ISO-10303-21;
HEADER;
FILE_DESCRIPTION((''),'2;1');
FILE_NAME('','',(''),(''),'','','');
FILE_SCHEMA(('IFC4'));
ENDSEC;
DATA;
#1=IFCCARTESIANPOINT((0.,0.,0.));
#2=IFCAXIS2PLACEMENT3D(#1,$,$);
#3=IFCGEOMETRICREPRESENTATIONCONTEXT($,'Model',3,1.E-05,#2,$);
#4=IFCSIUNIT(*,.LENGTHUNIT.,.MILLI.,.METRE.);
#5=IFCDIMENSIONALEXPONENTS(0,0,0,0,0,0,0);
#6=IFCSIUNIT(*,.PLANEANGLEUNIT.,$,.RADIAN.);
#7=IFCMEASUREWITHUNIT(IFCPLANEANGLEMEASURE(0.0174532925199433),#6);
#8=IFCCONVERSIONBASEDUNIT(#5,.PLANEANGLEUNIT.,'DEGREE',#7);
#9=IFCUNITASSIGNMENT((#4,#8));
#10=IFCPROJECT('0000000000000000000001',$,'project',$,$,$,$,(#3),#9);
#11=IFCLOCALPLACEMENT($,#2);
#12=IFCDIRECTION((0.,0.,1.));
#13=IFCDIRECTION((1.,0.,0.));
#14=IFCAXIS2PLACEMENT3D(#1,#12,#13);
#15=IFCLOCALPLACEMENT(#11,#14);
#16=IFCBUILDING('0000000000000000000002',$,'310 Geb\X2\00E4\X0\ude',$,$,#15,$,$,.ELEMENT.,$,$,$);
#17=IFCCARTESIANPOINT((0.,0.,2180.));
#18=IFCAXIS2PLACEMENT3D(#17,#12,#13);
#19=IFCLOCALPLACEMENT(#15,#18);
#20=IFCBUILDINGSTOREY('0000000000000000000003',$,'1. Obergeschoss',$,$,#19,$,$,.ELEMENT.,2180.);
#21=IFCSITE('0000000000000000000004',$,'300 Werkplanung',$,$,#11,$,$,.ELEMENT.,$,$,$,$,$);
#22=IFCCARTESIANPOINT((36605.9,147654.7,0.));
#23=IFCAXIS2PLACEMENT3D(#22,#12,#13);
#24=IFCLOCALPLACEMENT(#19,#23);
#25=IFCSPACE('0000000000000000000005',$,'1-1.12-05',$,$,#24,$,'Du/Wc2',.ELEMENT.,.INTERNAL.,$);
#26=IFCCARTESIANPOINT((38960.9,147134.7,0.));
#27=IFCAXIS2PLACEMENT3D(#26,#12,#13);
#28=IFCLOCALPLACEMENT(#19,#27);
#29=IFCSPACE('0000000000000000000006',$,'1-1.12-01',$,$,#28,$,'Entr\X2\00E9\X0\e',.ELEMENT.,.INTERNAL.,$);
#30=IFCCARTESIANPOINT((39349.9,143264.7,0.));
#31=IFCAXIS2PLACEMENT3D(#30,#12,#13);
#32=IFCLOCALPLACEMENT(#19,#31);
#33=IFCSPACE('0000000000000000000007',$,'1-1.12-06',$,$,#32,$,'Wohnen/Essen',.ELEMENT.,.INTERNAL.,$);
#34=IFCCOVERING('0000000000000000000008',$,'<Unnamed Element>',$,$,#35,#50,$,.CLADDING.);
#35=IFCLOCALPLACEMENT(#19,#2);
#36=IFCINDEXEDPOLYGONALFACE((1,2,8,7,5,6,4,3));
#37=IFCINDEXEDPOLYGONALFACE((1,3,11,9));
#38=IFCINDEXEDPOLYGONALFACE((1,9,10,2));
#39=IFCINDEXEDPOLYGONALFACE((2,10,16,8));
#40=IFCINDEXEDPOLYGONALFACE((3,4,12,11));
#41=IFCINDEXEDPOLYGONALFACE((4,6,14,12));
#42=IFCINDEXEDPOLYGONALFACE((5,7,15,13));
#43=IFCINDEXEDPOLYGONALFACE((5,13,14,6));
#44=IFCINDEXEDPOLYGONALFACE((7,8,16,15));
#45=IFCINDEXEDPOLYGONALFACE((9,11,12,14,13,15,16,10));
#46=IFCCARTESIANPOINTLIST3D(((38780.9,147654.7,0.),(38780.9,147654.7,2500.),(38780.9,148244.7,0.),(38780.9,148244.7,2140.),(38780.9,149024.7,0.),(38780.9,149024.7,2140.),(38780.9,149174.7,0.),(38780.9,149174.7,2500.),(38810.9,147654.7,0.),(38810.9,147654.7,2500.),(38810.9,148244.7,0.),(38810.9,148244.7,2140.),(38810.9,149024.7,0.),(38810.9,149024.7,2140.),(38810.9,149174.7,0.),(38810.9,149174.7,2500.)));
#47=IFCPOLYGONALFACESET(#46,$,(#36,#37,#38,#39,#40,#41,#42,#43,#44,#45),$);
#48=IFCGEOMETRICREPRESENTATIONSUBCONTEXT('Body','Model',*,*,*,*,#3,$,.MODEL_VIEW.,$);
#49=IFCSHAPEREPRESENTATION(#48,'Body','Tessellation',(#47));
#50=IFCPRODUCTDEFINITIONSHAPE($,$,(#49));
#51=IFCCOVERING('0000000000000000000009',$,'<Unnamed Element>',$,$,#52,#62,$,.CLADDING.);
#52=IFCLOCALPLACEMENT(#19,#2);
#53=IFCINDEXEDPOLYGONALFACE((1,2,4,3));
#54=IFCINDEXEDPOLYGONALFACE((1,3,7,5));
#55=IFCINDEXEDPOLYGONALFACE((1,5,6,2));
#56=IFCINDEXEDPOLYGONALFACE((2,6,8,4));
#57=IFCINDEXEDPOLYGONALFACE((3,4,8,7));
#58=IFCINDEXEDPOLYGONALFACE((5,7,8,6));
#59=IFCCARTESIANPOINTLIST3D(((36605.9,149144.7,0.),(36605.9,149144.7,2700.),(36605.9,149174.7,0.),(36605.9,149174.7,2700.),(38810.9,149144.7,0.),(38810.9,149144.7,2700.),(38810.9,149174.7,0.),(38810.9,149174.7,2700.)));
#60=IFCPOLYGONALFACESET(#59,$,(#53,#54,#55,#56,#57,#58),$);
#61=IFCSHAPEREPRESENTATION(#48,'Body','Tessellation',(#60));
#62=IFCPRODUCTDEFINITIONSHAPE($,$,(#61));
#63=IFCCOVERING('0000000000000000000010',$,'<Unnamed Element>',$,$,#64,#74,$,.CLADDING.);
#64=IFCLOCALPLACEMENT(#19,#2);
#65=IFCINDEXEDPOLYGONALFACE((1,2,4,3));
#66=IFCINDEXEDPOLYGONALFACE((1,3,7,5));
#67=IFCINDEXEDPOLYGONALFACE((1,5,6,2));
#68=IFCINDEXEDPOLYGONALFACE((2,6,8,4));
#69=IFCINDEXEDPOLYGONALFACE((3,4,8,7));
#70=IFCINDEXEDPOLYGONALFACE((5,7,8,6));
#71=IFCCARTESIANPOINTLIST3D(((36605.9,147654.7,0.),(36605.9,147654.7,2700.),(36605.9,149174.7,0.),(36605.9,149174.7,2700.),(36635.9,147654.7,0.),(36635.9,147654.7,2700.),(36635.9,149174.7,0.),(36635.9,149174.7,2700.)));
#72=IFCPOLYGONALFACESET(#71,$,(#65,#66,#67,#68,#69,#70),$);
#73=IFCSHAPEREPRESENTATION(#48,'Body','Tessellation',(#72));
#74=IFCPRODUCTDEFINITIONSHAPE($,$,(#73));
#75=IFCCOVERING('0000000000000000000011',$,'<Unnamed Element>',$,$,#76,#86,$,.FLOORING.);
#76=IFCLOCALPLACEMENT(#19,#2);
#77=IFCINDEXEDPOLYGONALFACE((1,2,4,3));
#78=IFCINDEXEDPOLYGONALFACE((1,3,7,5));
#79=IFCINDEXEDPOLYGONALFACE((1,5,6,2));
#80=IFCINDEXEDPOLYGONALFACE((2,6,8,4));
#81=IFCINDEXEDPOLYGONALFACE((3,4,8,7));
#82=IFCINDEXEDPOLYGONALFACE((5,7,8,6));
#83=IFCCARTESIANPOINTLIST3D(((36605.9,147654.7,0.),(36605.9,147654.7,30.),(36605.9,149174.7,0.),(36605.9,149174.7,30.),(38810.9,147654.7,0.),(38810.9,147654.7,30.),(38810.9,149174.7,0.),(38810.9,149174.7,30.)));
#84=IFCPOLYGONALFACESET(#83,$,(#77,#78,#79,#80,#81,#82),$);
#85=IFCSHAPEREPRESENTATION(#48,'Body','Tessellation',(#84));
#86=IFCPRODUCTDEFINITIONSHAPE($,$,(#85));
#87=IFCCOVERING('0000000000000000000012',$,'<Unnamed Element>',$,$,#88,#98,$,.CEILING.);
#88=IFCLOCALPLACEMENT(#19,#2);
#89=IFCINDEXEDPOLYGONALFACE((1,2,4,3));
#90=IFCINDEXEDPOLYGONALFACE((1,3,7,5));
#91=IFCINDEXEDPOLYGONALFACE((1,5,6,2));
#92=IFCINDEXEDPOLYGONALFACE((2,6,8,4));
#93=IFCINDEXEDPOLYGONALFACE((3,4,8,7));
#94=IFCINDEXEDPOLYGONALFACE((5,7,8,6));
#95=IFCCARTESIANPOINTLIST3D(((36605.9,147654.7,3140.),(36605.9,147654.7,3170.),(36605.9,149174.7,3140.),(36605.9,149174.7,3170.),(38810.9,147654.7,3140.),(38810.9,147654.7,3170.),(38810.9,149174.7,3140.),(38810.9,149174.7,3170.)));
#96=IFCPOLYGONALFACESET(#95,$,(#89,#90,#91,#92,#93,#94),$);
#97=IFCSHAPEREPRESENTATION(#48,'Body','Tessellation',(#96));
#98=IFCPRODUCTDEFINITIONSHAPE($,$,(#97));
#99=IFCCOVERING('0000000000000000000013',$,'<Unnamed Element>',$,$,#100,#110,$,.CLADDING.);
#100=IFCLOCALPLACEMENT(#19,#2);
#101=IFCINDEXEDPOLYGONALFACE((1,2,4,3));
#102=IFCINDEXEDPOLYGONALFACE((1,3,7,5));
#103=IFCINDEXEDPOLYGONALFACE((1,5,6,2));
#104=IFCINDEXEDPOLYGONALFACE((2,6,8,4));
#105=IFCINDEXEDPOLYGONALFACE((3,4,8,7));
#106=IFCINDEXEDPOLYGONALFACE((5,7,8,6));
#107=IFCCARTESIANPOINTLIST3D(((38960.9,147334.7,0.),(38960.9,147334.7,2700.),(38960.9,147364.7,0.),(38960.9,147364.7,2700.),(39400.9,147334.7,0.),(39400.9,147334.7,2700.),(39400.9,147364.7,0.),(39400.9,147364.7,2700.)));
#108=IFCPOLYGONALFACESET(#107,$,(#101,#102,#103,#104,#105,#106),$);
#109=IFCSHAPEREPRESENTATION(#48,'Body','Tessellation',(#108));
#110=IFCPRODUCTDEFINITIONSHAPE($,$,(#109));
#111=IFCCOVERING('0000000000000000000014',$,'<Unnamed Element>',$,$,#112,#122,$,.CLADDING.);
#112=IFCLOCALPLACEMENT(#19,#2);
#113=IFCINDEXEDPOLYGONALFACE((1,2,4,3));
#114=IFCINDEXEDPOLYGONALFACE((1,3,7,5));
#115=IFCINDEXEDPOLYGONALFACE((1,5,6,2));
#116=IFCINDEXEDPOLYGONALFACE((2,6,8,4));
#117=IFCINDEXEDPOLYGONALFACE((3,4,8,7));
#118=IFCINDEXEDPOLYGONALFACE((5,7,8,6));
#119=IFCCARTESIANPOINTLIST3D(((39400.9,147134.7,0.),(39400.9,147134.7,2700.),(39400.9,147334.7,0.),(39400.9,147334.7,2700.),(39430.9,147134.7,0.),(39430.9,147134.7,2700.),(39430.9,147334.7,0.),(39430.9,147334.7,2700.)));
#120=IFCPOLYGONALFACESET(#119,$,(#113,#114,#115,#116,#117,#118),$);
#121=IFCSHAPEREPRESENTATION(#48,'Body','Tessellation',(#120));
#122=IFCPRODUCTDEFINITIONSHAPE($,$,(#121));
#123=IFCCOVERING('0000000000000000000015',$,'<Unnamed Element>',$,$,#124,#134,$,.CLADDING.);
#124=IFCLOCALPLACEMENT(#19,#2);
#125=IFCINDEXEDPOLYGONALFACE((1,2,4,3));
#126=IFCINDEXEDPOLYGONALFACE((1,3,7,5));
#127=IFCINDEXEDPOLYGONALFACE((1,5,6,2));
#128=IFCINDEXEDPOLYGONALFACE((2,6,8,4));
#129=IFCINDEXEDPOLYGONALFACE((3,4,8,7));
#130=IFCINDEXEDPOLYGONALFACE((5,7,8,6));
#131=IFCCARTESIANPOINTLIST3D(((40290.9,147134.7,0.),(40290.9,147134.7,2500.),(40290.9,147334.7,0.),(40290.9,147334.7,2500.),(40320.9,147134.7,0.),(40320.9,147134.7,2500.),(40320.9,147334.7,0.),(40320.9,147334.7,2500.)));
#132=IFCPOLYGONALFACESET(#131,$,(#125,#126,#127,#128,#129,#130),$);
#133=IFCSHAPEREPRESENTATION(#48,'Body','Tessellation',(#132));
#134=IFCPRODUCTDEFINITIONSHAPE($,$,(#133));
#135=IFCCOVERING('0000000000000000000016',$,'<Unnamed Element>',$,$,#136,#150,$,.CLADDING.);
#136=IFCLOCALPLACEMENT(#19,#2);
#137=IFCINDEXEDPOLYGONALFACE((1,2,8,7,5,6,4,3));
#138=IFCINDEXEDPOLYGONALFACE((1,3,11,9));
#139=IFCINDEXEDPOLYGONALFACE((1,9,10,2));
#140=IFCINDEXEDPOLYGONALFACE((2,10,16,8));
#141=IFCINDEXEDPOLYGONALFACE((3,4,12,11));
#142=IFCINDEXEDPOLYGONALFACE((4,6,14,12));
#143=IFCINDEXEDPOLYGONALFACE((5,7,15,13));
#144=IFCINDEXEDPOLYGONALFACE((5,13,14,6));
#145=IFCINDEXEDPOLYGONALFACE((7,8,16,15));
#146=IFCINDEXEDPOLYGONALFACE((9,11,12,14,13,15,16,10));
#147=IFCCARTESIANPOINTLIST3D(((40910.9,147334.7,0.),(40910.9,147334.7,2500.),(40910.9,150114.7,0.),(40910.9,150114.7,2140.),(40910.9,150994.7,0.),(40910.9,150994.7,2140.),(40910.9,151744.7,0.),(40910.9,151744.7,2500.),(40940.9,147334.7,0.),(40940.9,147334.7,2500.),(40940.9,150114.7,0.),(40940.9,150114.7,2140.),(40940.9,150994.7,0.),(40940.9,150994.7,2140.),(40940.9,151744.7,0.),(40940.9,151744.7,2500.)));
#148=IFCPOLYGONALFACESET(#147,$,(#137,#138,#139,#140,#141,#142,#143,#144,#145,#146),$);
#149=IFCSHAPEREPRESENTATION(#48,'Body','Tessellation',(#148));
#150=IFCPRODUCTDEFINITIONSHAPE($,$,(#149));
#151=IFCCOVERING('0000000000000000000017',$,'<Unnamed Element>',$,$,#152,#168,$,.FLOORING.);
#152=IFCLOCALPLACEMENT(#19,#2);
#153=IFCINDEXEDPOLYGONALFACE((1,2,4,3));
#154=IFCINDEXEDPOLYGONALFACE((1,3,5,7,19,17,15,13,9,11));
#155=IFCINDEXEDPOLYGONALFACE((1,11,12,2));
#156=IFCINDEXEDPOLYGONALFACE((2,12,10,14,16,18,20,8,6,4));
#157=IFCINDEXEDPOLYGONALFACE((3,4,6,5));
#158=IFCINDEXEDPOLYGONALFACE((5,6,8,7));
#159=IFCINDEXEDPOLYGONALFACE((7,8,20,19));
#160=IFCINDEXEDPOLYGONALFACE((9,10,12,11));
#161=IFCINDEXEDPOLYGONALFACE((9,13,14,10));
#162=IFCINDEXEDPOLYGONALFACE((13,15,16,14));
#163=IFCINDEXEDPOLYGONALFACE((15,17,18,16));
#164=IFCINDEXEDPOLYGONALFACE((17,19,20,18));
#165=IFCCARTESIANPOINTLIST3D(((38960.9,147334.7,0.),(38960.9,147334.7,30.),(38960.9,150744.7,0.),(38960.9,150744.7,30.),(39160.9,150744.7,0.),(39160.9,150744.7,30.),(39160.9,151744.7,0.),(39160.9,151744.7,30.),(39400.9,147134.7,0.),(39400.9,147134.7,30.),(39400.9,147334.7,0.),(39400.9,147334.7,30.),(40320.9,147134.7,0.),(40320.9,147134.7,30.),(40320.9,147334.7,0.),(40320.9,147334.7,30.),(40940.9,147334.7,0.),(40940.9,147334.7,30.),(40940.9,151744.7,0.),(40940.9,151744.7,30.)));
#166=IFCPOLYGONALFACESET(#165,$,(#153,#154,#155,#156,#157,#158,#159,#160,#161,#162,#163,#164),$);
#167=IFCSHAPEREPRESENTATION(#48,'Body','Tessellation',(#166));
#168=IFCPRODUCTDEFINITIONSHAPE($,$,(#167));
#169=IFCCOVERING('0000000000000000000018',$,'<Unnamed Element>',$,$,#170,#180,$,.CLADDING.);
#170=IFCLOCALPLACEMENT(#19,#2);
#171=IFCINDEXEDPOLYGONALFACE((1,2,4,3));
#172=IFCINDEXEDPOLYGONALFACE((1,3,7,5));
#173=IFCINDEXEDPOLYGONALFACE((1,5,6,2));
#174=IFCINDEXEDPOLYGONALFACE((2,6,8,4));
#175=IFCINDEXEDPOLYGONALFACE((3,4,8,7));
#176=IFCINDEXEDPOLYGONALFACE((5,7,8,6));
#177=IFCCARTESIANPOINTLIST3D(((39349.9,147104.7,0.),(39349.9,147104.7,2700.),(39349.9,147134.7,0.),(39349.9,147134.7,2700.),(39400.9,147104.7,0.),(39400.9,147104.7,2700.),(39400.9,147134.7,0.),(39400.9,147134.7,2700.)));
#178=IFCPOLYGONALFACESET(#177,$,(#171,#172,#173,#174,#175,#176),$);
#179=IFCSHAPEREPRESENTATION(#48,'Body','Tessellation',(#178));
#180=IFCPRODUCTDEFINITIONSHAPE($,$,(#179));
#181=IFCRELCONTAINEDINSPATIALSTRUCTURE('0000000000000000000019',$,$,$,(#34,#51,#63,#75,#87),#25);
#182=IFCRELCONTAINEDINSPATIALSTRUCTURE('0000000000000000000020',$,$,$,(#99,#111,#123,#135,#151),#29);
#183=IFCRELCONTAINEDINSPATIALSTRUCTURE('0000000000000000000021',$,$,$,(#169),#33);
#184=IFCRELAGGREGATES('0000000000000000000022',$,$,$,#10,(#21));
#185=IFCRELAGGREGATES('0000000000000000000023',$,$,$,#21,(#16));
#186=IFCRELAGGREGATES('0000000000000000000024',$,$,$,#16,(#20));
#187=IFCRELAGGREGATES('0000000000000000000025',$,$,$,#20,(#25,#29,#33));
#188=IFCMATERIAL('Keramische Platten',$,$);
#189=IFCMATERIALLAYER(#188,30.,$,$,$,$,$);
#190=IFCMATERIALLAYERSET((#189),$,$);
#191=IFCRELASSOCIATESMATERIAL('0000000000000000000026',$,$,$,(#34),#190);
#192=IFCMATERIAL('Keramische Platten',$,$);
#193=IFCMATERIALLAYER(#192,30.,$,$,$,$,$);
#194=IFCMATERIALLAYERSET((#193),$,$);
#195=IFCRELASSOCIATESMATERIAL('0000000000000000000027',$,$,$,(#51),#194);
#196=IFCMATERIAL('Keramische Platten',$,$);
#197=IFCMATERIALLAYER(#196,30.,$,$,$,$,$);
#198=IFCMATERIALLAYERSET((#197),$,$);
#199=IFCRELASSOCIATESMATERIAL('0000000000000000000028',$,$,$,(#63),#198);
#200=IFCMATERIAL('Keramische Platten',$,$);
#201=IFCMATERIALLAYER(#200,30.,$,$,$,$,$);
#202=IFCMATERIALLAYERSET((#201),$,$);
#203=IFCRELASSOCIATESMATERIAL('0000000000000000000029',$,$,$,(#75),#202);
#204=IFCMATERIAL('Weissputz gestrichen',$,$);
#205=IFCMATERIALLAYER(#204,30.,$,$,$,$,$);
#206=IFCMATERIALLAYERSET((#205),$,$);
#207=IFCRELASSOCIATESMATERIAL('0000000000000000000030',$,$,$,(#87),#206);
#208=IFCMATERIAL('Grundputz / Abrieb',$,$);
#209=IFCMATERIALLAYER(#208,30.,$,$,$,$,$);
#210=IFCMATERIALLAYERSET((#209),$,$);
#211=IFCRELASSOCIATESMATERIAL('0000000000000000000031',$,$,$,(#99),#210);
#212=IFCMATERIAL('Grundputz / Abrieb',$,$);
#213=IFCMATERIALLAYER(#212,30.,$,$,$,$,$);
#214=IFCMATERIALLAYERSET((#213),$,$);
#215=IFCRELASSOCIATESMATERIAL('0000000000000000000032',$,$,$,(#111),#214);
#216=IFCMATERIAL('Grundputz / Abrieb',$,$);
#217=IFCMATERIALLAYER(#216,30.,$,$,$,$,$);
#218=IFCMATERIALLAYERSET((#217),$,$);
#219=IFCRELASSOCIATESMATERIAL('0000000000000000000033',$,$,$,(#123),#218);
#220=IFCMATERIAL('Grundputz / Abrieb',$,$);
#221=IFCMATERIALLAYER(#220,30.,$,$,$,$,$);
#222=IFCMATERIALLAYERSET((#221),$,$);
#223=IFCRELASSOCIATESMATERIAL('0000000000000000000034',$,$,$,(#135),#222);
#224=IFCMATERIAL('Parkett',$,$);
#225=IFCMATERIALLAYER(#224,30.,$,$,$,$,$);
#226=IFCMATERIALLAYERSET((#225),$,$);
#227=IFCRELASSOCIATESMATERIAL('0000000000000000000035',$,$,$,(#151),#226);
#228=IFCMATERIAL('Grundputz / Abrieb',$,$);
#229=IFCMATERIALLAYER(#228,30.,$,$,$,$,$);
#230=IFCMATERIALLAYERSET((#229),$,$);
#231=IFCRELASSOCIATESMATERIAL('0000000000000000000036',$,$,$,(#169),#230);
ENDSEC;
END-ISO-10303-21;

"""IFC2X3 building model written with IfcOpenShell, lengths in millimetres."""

from ifc_helpers import new_model, entity, si_unit, converted_unit, frame, frame_2d, origin, origin_with_axes, place, context, subcontext, project, spatial, polyline, rectangle, outline, extrude, material, layer, layer_set, layer_usage, element, save


model = new_model("IFC2X3")

# Units and contexts
model_context = context("Model", 3, precision=1e-05, world=origin())
body_context = subcontext(model_context, "Body", "Model", "MODEL_VIEW")
ifc_project = project(units=[si_unit("LENGTHUNIT", "METRE", prefix="MILLI"), converted_unit("PLANEANGLEUNIT", "DEGREE", entity("IfcPlaneAngleMeasure", 0.0174532925199433), si_unit("PLANEANGLEUNIT", "RADIAN"), dimensions=[0, 0, 0, 0, 0, 0, 0])], contexts=[model_context])

# Site, building, storey
site_placement = place(None, origin())
site = spatial("IfcSite", under=ifc_project, at=site_placement, Name="300 Werkplanung", CompositionType="ELEMENT")
building_placement = place(site_placement, origin_with_axes())
building = spatial("IfcBuilding", under=site, at=building_placement, Name="310 Gebäude", CompositionType="ELEMENT")
storey_placement = place(building_placement, frame((0.0, 0.0, 2180.0), z_axis=(0.0, 0.0, 1.0), x_axis=(1.0, 0.0, 0.0)))
storey = spatial("IfcBuildingStorey", under=building, at=storey_placement, Name="1. Obergeschoss", CompositionType="ELEMENT", Elevation=2180.0)

# Shared definitions
space_1_placement = place(storey_placement, frame((36605.9, 147654.7, 0.0), z_axis=(0.0, 0.0, 1.0), x_axis=(1.0, 0.0, 0.0)))
space_1 = spatial("IfcSpace", under=storey, at=space_1_placement, Name="1-1.12-05", LongName="Du/Wc2", CompositionType="ELEMENT", InteriorOrExteriorSpace="INTERNAL")

# Coverings
ifc_material_1 = material(Name="Keramische Platten")
ifc_layer_1 = layer(ifc_material_1, 30.0)
ifc_layer_set_1 = layer_set([ifc_layer_1])
ifc_layer_usage_1 = layer_usage(ifc_layer_set_1, "AXIS3", "POSITIVE", 0.0)
covering_1_placement = place(space_1_placement, frame((2205.0, 0.0, 0.0), z_axis=(0.0, 0.0, 1.0), x_axis=(0.0, 1.0, 0.0)))
element("IfcCovering", 1, at=covering_1_placement, inside=space_1, material=ifc_layer_usage_1, Name="<Unnamed Element>", PredefinedType="CLADDING", context=body_context, shape_type="SweptSolid", body=[
    extrude(outline(polyline([(1520.0, 0.0), (1520.0, -2500.0), (0.0, -2500.0), (0.0, 0.0), (590.0, 0.0), (590.0, -2140.0), (1370.0, -2140.0), (1370.0, 0.0), (1520.0, 0.0)])), frame((0.0, 0.0, 0.0), z_axis=(0.0, 1.0, 0.0), x_axis=(1.0, 0.0, 0.0)), (0.0, 0.0, 1.0), 30.0),
])
ifc_material_2 = material(Name="Keramische Platten")
ifc_layer_2 = layer(ifc_material_2, 30.0)
ifc_layer_set_2 = layer_set([ifc_layer_2])
ifc_layer_usage_2 = layer_usage(ifc_layer_set_2, "AXIS3", "POSITIVE", 0.0)
covering_2_placement = place(space_1_placement, frame((2205.0, 1520.0, 0.0), z_axis=(0.0, 0.0, 1.0), x_axis=(-1.0, 0.0, 0.0)))
element("IfcCovering", 2, at=covering_2_placement, inside=space_1, material=ifc_layer_usage_2, Name="<Unnamed Element>", PredefinedType="CLADDING", context=body_context, shape_type="SweptSolid", body=[
    extrude(rectangle(XDim=2700.0, YDim=2205.0, at=frame_2d((-1102.5, 1350.0), x_axis=(0.0, 1.0))), frame((2205.0, 0.0, 2700.0), z_axis=(0.0, 1.0, 0.0), x_axis=(1.0, 0.0, 0.0)), (0.0, 0.0, 1.0), 30.0),
])
ifc_material_3 = material(Name="Keramische Platten")
ifc_layer_3 = layer(ifc_material_3, 30.0)
ifc_layer_set_3 = layer_set([ifc_layer_3])
ifc_layer_usage_3 = layer_usage(ifc_layer_set_3, "AXIS3", "POSITIVE", 0.0)
covering_3_placement = place(space_1_placement, frame((0.0, 1520.0, 0.0), z_axis=(0.0, 0.0, 1.0), x_axis=(0.0, -1.0, 0.0)))
element("IfcCovering", 3, at=covering_3_placement, inside=space_1, material=ifc_layer_usage_3, Name="<Unnamed Element>", PredefinedType="CLADDING", context=body_context, shape_type="SweptSolid", body=[
    extrude(rectangle(XDim=2700.0, YDim=1520.0, at=frame_2d((-760.0, 1350.0), x_axis=(0.0, 1.0))), frame((1520.0, 0.0, 2700.0), z_axis=(0.0, 1.0, 0.0), x_axis=(1.0, 0.0, 0.0)), (0.0, 0.0, 1.0), 30.0),
])
ifc_material_4 = material(Name="Keramische Platten")
ifc_layer_4 = layer(ifc_material_4, 30.0)
ifc_layer_set_4 = layer_set([ifc_layer_4])
ifc_layer_usage_4 = layer_usage(ifc_layer_set_4, "AXIS3", "POSITIVE", 0.0)
covering_4_placement = place(space_1_placement, origin_with_axes())
element("IfcCovering", 4, at=covering_4_placement, inside=space_1, material=ifc_layer_usage_4, Name="<Unnamed Element>", PredefinedType="FLOORING", context=body_context, shape_type="SweptSolid", body=[
    extrude(rectangle(XDim=2205.0, YDim=1520.0, at=frame_2d((-1102.5, -760.0), x_axis=(-1.0, 0.0))), frame((2205.0, 1520.0, 0.0), z_axis=(0.0, 0.0, 1.0), x_axis=(1.0, 0.0, 0.0)), (0.0, 0.0, 1.0), 30.0),
])
ifc_material_5 = material(Name="Weissputz gestrichen")
ifc_layer_5 = layer(ifc_material_5, 30.0)
ifc_layer_set_5 = layer_set([ifc_layer_5])
ifc_layer_usage_5 = layer_usage(ifc_layer_set_5, "AXIS3", "POSITIVE", 0.0)
covering_5_placement = place(space_1_placement, frame((1102.5, 760.0, 3170.0), z_axis=(0.0, 0.0, -1.0), x_axis=(1.0, 0.0, 0.0)))
element("IfcCovering", 5, at=covering_5_placement, inside=space_1, material=ifc_layer_usage_5, Name="<Unnamed Element>", PredefinedType="CEILING", context=body_context, shape_type="SweptSolid", body=[
    extrude(rectangle(XDim=2205.0, YDim=1520.0, at=frame_2d((1102.5, 760.0), x_axis=(1.0, 0.0))), frame((-1102.5, -760.0, 0.0), z_axis=(0.0, 0.0, 1.0), x_axis=(1.0, 0.0, 0.0)), (0.0, 0.0, 1.0), 30.0),
])

# Shared definitions
space_2_placement = place(storey_placement, frame((38960.9, 147134.7, 0.0), z_axis=(0.0, 0.0, 1.0), x_axis=(1.0, 0.0, 0.0)))
space_2 = spatial("IfcSpace", under=storey, at=space_2_placement, Name="1-1.12-01", LongName="Entrée", CompositionType="ELEMENT", InteriorOrExteriorSpace="INTERNAL")

# Coverings
ifc_material_6 = material(Name="Grundputz / Abrieb")
ifc_layer_6 = layer(ifc_material_6, 30.0)
ifc_layer_set_6 = layer_set([ifc_layer_6])
ifc_layer_usage_6 = layer_usage(ifc_layer_set_6, "AXIS3", "POSITIVE", 0.0)
covering_6_placement = place(space_2_placement, frame((0.0, 200.0, 0.0), z_axis=(0.0, 0.0, 1.0), x_axis=(1.0, 0.0, 0.0)))
element("IfcCovering", 6, at=covering_6_placement, inside=space_2, material=ifc_layer_usage_6, Name="<Unnamed Element>", PredefinedType="CLADDING", context=body_context, shape_type="SweptSolid", body=[
    extrude(rectangle(XDim=2700.0, YDim=440.0, at=frame_2d((-220.0, 1350.0), x_axis=(0.0, 1.0))), frame((440.0, 0.0, 2700.0), z_axis=(0.0, 1.0, 0.0), x_axis=(1.0, 0.0, 0.0)), (0.0, 0.0, 1.0), 30.0),
])
ifc_material_7 = material(Name="Grundputz / Abrieb")
ifc_layer_7 = layer(ifc_material_7, 30.0)
ifc_layer_set_7 = layer_set([ifc_layer_7])
ifc_layer_usage_7 = layer_usage(ifc_layer_set_7, "AXIS3", "POSITIVE", 0.0)
covering_7_placement = place(space_2_placement, frame((440.0, 200.0, 0.0), z_axis=(0.0, 0.0, 1.0), x_axis=(0.0, -1.0, 0.0)))
element("IfcCovering", 7, at=covering_7_placement, inside=space_2, material=ifc_layer_usage_7, Name="<Unnamed Element>", PredefinedType="CLADDING", context=body_context, shape_type="SweptSolid", body=[
    extrude(rectangle(XDim=2700.0, YDim=200.0, at=frame_2d((-100.0, 1350.0), x_axis=(0.0, 1.0))), frame((200.0, 0.0, 2700.0), z_axis=(0.0, 1.0, 0.0), x_axis=(1.0, 0.0, 0.0)), (0.0, 0.0, 1.0), 30.0),
])
ifc_material_8 = material(Name="Grundputz / Abrieb")
ifc_layer_8 = layer(ifc_material_8, 30.0)
ifc_layer_set_8 = layer_set([ifc_layer_8])
ifc_layer_usage_8 = layer_usage(ifc_layer_set_8, "AXIS3", "POSITIVE", 0.0)
covering_8_placement = place(space_2_placement, frame((1360.0, 0.0, 0.0), z_axis=(0.0, 0.0, 1.0), x_axis=(0.0, 1.0, 0.0)))
element("IfcCovering", 8, at=covering_8_placement, inside=space_2, material=ifc_layer_usage_8, Name="<Unnamed Element>", PredefinedType="CLADDING", context=body_context, shape_type="SweptSolid", body=[
    extrude(rectangle(XDim=2500.0, YDim=200.0, at=frame_2d((-100.0, 1250.0), x_axis=(0.0, 1.0))), frame((200.0, 0.0, 2500.0), z_axis=(0.0, 1.0, 0.0), x_axis=(1.0, 0.0, 0.0)), (0.0, 0.0, 1.0), 30.0),
])
ifc_material_9 = material(Name="Grundputz / Abrieb")
ifc_layer_9 = layer(ifc_material_9, 30.0)
ifc_layer_set_9 = layer_set([ifc_layer_9])
ifc_layer_usage_9 = layer_usage(ifc_layer_set_9, "AXIS3", "POSITIVE", 0.0)
covering_9_placement = place(space_2_placement, frame((1980.0, 200.0, 0.0), z_axis=(0.0, 0.0, 1.0), x_axis=(0.0, 1.0, 0.0)))
element("IfcCovering", 9, at=covering_9_placement, inside=space_2, material=ifc_layer_usage_9, Name="<Unnamed Element>", PredefinedType="CLADDING", context=body_context, shape_type="SweptSolid", body=[
    extrude(outline(polyline([(4410.0, 0.0), (4410.0, -2500.0), (0.0, -2500.0), (0.0, 0.0), (2780.0, 0.0), (2780.0, -2140.0), (3660.0, -2140.0), (3660.0, 0.0), (4410.0, 0.0)])), frame((0.0, 0.0, 0.0), z_axis=(0.0, 1.0, 0.0), x_axis=(1.0, 0.0, 0.0)), (0.0, 0.0, 1.0), 30.0),
])
ifc_material_10 = material(Name="Parkett")
ifc_layer_10 = layer(ifc_material_10, 30.0)
ifc_layer_set_10 = layer_set([ifc_layer_10])
ifc_layer_usage_10 = layer_usage(ifc_layer_set_10, "AXIS3", "POSITIVE", 0.0)
covering_10_placement = place(space_2_placement, origin_with_axes())
element("IfcCovering", 10, at=covering_10_placement, inside=space_2, material=ifc_layer_usage_10, Name="<Unnamed Element>", PredefinedType="FLOORING", context=body_context, shape_type="SweptSolid", body=[
    extrude(outline(polyline([(0.0, 3610.0), (0.0, 200.0), (440.0, 200.0), (440.0, 0.0), (1360.0, 0.0), (1360.0, 200.0), (1980.0, 200.0), (1980.0, 4610.0), (200.0, 4610.0), (200.0, 3610.0), (0.0, 3610.0)])), origin_with_axes(), (0.0, 0.0, 1.0), 30.0),
])

# Shared definitions
space_3_placement = place(storey_placement, frame((39349.9, 143264.7, 0.0), z_axis=(0.0, 0.0, 1.0), x_axis=(1.0, 0.0, 0.0)))
space_3 = spatial("IfcSpace", under=storey, at=space_3_placement, Name="1-1.12-06", LongName="Wohnen/Essen", CompositionType="ELEMENT", InteriorOrExteriorSpace="INTERNAL")

# Covering
ifc_material_11 = material(Name="Grundputz / Abrieb")
ifc_layer_11 = layer(ifc_material_11, 30.0)
ifc_layer_set_11 = layer_set([ifc_layer_11])
ifc_layer_usage_11 = layer_usage(ifc_layer_set_11, "AXIS3", "POSITIVE", 0.0)
covering_11_placement = place(space_3_placement, frame((51.0, 3870.0, 0.0), z_axis=(0.0, 0.0, 1.0), x_axis=(-1.0, 0.0, 0.0)))
element("IfcCovering", 11, at=covering_11_placement, inside=space_3, material=ifc_layer_usage_11, Name="<Unnamed Element>", PredefinedType="CLADDING", context=body_context, shape_type="SweptSolid", body=[
    extrude(rectangle(XDim=2700.0, YDim=51.0, at=frame_2d((-25.5, 1350.0), x_axis=(0.0, 1.0))), frame((51.0, 0.0, 2700.0), z_axis=(0.0, 1.0, 0.0), x_axis=(1.0, 0.0, 0.0)), (0.0, 0.0, 1.0), 30.0),
])

save(model, "model.ifc")
